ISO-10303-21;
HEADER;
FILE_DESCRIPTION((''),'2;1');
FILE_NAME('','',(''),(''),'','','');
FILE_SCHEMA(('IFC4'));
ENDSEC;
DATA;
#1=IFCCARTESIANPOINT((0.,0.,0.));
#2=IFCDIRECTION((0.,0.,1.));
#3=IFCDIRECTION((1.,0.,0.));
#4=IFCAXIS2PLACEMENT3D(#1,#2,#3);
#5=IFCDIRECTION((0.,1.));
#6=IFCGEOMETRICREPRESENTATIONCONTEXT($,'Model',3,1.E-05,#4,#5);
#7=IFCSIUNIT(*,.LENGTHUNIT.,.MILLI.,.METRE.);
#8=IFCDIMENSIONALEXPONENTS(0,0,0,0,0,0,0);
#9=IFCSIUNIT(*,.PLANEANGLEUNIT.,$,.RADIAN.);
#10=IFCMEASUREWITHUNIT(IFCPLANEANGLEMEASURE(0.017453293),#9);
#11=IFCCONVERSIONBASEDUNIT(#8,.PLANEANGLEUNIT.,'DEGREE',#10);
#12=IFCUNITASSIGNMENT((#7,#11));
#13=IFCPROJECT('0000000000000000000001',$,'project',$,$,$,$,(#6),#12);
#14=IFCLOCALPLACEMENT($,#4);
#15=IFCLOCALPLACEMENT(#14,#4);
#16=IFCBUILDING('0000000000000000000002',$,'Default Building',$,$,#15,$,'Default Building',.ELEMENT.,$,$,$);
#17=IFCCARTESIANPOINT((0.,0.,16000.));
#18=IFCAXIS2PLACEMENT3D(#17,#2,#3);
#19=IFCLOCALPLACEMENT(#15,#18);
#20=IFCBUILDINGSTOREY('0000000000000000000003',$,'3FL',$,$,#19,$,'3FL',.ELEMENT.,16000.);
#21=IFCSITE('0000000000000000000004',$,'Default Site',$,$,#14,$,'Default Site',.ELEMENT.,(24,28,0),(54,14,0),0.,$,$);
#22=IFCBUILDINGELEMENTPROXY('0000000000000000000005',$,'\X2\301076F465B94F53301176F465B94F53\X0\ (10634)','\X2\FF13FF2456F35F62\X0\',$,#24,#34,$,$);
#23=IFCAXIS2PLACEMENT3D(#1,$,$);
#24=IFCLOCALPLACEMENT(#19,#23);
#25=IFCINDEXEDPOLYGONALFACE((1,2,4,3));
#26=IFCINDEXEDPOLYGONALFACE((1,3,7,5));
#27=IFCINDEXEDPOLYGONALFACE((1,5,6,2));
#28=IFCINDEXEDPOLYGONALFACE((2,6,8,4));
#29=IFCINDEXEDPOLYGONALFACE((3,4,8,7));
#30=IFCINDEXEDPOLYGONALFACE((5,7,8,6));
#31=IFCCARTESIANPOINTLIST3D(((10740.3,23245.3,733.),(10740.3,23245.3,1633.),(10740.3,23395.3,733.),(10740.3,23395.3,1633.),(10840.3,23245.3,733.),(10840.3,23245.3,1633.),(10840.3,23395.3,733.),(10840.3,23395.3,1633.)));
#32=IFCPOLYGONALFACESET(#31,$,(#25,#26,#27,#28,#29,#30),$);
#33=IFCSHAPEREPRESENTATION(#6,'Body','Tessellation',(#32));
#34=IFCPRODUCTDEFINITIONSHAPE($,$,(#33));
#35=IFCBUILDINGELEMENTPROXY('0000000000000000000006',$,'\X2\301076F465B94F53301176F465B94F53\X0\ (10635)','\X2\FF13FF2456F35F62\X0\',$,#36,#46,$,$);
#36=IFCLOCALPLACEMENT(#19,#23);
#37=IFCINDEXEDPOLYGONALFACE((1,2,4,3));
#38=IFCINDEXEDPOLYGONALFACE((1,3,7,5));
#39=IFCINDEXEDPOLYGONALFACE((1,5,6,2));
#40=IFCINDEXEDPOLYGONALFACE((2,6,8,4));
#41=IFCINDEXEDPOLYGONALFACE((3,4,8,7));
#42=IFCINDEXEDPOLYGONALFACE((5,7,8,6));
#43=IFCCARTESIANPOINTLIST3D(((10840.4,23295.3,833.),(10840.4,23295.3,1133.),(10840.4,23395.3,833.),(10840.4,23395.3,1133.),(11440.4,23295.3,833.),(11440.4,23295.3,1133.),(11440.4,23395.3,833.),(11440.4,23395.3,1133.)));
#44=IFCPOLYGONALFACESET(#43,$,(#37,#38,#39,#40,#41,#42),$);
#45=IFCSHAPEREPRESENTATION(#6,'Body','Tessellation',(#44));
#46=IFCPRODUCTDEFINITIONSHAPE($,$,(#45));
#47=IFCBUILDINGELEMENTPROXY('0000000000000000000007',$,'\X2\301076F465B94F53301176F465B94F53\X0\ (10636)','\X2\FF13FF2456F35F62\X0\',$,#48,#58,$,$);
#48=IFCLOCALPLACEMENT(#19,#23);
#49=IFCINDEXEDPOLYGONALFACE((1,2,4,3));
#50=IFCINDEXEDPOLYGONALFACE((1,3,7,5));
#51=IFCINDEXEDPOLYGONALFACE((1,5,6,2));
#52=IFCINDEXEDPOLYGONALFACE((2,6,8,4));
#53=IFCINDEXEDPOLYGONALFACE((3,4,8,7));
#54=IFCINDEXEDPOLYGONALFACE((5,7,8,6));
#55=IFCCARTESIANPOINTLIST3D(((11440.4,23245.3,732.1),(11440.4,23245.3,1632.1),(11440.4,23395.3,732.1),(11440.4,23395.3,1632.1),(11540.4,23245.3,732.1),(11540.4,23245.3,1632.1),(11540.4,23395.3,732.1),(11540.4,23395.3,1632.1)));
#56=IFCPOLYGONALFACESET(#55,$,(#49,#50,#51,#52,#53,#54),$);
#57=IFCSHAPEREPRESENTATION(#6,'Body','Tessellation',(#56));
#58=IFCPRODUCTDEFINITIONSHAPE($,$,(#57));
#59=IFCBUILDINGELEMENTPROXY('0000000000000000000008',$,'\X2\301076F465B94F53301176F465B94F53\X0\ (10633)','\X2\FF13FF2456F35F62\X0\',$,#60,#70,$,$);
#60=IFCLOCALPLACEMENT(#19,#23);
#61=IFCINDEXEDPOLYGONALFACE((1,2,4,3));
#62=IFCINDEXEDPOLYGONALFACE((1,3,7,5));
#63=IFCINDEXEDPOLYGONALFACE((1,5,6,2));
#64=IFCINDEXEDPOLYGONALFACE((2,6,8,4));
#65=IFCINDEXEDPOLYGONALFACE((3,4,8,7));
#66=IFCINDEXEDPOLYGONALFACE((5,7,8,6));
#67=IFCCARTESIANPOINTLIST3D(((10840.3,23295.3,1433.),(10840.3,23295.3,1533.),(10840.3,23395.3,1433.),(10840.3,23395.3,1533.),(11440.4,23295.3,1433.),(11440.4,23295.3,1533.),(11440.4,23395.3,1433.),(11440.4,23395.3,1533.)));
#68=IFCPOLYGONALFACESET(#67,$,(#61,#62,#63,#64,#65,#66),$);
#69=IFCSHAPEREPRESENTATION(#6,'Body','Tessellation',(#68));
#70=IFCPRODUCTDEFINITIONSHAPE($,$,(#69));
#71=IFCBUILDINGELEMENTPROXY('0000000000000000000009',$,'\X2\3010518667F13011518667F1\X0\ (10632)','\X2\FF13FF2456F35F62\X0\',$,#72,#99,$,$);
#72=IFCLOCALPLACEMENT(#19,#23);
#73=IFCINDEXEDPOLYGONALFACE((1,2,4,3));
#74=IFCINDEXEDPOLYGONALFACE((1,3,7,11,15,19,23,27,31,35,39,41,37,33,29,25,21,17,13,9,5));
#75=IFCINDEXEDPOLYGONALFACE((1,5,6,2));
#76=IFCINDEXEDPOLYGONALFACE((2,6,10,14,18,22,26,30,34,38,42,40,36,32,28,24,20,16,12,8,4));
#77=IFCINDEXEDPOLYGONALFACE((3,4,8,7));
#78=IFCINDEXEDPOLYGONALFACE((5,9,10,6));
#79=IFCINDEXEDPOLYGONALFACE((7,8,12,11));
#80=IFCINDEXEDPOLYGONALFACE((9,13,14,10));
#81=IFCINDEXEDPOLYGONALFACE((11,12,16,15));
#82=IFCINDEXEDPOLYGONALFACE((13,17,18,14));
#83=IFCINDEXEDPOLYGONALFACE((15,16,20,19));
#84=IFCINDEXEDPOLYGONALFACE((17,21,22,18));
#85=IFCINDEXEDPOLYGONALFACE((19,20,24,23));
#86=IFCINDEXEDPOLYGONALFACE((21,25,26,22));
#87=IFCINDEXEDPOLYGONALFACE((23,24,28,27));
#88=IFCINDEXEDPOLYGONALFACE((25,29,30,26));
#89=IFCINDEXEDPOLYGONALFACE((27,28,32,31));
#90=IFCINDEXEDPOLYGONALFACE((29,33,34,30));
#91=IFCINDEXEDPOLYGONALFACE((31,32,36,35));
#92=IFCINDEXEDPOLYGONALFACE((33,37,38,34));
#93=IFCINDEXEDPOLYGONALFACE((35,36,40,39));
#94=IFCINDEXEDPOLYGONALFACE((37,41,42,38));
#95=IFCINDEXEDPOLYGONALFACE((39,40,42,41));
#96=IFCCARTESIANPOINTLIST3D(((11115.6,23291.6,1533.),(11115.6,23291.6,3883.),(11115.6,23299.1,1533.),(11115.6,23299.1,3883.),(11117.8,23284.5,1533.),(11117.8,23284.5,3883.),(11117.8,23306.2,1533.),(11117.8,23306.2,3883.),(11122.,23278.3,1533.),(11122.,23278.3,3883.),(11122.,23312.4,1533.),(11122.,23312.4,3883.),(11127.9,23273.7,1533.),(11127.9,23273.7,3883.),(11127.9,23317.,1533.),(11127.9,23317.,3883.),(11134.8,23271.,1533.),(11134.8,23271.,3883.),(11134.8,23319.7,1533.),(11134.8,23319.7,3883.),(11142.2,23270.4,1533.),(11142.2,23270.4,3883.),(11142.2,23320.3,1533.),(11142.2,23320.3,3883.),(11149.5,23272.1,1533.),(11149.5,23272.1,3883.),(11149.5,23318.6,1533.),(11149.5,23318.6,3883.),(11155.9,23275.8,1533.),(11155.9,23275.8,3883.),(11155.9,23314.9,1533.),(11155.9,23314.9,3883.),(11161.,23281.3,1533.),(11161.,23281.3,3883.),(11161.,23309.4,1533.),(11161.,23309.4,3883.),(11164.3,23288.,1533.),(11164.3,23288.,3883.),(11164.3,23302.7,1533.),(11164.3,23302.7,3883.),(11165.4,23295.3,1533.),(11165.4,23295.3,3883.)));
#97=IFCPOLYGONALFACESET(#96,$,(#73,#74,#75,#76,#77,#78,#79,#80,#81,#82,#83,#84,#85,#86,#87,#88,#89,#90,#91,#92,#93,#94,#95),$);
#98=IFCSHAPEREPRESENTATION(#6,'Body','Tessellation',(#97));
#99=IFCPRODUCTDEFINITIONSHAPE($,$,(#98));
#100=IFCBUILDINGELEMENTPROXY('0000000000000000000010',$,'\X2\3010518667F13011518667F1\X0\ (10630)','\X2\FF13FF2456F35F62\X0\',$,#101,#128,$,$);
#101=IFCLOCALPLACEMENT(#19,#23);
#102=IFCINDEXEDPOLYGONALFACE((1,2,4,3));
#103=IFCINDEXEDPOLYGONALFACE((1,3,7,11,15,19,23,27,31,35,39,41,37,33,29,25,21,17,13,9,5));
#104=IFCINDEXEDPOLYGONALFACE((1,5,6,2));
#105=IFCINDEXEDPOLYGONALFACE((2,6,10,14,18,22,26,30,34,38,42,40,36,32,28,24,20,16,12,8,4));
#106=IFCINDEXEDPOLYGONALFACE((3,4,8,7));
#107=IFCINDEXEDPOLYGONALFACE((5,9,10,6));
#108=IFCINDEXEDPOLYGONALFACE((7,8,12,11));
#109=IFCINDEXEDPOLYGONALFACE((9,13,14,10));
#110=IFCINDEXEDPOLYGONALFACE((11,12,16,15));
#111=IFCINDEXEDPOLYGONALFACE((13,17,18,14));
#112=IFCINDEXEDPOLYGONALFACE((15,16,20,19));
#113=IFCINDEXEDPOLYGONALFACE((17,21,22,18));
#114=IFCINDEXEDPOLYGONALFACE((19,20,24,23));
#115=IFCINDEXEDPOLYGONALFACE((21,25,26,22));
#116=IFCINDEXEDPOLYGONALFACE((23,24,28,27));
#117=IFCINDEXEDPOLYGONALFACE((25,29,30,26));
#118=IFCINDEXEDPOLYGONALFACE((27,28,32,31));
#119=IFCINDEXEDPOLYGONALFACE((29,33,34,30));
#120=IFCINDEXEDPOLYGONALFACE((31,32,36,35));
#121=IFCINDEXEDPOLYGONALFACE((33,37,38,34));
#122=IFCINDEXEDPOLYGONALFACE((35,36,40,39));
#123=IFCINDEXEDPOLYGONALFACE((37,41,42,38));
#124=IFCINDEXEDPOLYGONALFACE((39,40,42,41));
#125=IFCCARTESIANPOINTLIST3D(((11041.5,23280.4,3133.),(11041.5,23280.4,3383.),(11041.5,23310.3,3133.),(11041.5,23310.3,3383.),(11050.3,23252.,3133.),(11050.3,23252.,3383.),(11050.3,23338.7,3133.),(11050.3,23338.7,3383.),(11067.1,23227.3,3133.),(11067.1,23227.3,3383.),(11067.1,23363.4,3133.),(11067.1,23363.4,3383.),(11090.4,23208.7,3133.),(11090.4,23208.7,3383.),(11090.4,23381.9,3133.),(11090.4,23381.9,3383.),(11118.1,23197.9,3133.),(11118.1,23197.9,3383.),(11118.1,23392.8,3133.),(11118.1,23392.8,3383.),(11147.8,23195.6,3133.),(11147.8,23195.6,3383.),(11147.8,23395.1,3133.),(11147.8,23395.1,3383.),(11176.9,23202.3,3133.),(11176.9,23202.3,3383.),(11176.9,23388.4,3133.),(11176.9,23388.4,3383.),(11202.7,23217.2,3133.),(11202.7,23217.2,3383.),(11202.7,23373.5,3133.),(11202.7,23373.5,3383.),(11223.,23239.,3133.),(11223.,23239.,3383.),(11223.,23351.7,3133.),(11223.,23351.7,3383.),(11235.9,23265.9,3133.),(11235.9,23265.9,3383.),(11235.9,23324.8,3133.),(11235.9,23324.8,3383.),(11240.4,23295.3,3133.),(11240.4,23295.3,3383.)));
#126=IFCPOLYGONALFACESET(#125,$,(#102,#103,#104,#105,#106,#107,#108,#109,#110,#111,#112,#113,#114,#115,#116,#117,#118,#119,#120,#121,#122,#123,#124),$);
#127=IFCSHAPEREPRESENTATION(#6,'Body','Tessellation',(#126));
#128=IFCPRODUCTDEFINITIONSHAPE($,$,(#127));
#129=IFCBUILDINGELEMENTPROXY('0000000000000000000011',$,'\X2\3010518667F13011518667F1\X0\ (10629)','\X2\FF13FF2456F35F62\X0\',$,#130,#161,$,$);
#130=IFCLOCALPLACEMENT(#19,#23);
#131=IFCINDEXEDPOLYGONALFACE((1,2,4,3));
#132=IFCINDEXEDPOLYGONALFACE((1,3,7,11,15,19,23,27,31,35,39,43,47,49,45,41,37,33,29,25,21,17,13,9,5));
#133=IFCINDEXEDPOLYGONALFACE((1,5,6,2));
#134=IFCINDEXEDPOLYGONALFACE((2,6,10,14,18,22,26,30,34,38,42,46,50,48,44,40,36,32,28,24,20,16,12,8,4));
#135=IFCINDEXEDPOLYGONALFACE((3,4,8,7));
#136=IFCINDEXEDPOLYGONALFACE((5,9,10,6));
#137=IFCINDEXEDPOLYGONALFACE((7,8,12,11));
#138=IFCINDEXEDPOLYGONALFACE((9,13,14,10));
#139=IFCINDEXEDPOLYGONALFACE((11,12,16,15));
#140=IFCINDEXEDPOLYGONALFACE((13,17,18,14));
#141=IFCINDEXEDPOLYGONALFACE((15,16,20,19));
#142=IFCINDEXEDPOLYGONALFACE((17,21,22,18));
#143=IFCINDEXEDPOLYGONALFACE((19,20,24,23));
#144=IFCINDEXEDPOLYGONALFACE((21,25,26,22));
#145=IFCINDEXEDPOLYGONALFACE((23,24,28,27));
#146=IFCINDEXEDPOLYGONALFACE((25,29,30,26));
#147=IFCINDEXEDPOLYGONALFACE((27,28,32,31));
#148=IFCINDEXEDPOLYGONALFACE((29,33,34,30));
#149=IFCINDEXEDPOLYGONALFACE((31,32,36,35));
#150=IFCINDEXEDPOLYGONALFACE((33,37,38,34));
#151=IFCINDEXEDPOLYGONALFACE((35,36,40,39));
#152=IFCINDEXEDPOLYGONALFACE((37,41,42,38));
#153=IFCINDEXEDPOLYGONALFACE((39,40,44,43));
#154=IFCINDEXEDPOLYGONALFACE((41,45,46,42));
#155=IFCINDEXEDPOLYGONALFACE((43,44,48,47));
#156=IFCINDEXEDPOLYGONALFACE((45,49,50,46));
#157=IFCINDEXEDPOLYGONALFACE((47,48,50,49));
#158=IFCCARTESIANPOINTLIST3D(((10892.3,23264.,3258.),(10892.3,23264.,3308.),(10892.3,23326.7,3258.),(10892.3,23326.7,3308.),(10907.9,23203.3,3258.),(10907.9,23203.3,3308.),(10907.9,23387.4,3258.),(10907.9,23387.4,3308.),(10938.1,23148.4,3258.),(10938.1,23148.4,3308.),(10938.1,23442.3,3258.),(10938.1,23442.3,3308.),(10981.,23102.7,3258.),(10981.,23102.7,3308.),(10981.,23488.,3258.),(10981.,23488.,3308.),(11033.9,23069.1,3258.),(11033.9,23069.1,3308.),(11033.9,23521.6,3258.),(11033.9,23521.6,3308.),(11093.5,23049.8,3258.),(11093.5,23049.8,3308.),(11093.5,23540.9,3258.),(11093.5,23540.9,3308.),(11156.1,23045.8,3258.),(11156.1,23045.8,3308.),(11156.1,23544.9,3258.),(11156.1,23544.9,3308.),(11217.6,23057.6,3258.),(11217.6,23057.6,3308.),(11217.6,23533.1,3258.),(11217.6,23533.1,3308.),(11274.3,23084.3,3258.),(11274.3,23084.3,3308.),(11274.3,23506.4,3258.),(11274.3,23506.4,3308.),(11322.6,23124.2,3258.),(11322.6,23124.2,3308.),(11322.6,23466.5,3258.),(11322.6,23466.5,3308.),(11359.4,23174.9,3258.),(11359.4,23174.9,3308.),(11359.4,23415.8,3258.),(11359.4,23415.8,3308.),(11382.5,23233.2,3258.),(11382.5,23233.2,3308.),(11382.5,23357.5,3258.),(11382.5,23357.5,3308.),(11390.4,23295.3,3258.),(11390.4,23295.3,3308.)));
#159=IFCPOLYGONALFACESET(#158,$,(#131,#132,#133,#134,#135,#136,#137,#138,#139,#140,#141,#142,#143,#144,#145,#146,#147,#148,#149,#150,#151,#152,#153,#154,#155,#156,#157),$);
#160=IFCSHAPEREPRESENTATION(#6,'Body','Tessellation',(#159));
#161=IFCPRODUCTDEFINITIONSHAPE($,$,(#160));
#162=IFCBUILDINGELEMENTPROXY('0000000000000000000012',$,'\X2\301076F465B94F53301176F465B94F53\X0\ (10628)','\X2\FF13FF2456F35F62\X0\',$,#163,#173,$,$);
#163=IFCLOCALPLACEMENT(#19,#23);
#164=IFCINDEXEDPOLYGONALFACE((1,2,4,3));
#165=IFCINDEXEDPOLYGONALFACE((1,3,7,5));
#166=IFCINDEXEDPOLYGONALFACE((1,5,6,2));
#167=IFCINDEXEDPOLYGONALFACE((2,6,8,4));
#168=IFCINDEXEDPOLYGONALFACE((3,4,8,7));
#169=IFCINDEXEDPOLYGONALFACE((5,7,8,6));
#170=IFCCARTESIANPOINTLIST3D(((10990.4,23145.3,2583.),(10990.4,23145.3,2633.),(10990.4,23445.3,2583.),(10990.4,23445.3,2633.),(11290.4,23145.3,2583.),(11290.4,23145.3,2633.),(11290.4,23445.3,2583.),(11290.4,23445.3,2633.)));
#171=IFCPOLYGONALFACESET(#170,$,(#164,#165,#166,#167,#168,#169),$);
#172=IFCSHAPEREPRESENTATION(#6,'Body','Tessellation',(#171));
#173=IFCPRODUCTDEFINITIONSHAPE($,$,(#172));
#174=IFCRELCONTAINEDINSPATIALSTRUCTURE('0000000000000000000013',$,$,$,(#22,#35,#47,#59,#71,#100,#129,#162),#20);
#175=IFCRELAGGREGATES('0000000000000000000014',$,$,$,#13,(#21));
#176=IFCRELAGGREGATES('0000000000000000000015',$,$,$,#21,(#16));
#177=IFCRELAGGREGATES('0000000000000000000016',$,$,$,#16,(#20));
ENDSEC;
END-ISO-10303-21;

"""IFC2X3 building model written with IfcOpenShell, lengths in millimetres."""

from ifc_helpers import new_model, entity, si_unit, converted_unit, direction, frame, origin_with_axes, origin_2d_with_axis, place, context, project, spatial, rectangle, circle, extrude, source, transform, mapped, element, save


model = new_model("IFC2X3")

# Units and contexts
model_context = context("Model", 3, precision=1e-05, world=origin_with_axes(), true_north=direction((0.0, 1.0)))
ifc_project = project(units=[si_unit("LENGTHUNIT", "METRE", prefix="MILLI"), converted_unit("PLANEANGLEUNIT", "DEGREE", entity("IfcPlaneAngleMeasure", 0.017453293), si_unit("PLANEANGLEUNIT", "RADIAN"), dimensions=[0, 0, 0, 0, 0, 0, 0])], contexts=[model_context])

# Site, building, storey
site_placement = place(None, origin_with_axes())
site = spatial("IfcSite", under=ifc_project, at=site_placement, Name="Default Site", LongName="Default Site", CompositionType="ELEMENT", RefLatitude=(24, 28, 0), RefLongitude=(54, 14, 0), RefElevation=0.0)
building_placement = place(site_placement, origin_with_axes())
building = spatial("IfcBuilding", under=site, at=building_placement, Name="Default Building", LongName="Default Building", CompositionType="ELEMENT")
storey_placement = place(building_placement, frame((0.0, 0.0, 16000.0), z_axis=(0.0, 0.0, 1.0), x_axis=(1.0, 0.0, 0.0)))
storey = spatial("IfcBuildingStorey", under=building, at=storey_placement, Name="3FL", LongName="3FL", CompositionType="ELEMENT", Elevation=16000.0)

# Building element proxies
shared_shape_1 = source(origin_with_axes(), model_context, "Body", "SweptSolid", [
    extrude(rectangle(XDim=100.0, YDim=150.0, at=origin_2d_with_axis()), origin_with_axes(), (0.0, 0.0, 1.0), 900.0),
])
proxy_1_placement = place(storey_placement, frame((10790.3, 23320.3, 733.0), z_axis=(0.0, 0.0, 1.0), x_axis=(1.0, 0.0, 0.0)))
element("IfcBuildingElementProxy", 1, at=proxy_1_placement, inside=storey, Name="【直方体】直方体 (10634)", Description="３Ｄ図形", context=model_context, shape_type="MappedRepresentation", body=[
    mapped(shared_shape_1, transform((0.0, 0.0, 0.0))),
])
shared_shape_2 = source(origin_with_axes(), model_context, "Body", "SweptSolid", [
    extrude(rectangle(XDim=600.0, YDim=100.0, at=origin_2d_with_axis()), origin_with_axes(), (0.0, 0.0, 1.0), 300.0),
])
proxy_2_placement = place(storey_placement, frame((11140.4, 23345.3, 833.0), z_axis=(0.0, 0.0, 1.0), x_axis=(1.0, 0.0, 0.0)))
element("IfcBuildingElementProxy", 2, at=proxy_2_placement, inside=storey, Name="【直方体】直方体 (10635)", Description="３Ｄ図形", context=model_context, shape_type="MappedRepresentation", body=[
    mapped(shared_shape_2, transform((0.0, 0.0, 0.0))),
])
shared_shape_3 = source(origin_with_axes(), model_context, "Body", "SweptSolid", [
    extrude(rectangle(XDim=100.0, YDim=150.0, at=origin_2d_with_axis()), origin_with_axes(), (0.0, 0.0, 1.0), 900.0),
])
proxy_3_placement = place(storey_placement, frame((11490.4, 23320.3, 732.1), z_axis=(0.0, 0.0, 1.0), x_axis=(1.0, 0.0, 0.0)))
element("IfcBuildingElementProxy", 3, at=proxy_3_placement, inside=storey, Name="【直方体】直方体 (10636)", Description="３Ｄ図形", context=model_context, shape_type="MappedRepresentation", body=[
    mapped(shared_shape_3, transform((0.0, 0.0, 0.0))),
])
shared_shape_4 = source(origin_with_axes(), model_context, "Body", "SweptSolid", [
    extrude(rectangle(XDim=600.2, YDim=100.0, at=origin_2d_with_axis()), origin_with_axes(), (0.0, 0.0, 1.0), 100.0),
])
proxy_4_placement = place(storey_placement, frame((11140.4, 23345.3, 1433.0), z_axis=(0.0, 0.0, 1.0), x_axis=(1.0, 0.0, 0.0)))
element("IfcBuildingElementProxy", 4, at=proxy_4_placement, inside=storey, Name="【直方体】直方体 (10633)", Description="３Ｄ図形", context=model_context, shape_type="MappedRepresentation", body=[
    mapped(shared_shape_4, transform((0.0, 0.0, 0.0))),
])
shared_shape_5 = source(origin_with_axes(), model_context, "Body", "SweptSolid", [
    extrude(circle(Radius=25.0, at=origin_2d_with_axis()), origin_with_axes(), (0.0, 0.0, 1.0), 2350.0),
])
proxy_5_placement = place(storey_placement, frame((11140.4, 23295.3, 1533.0), z_axis=(0.0, 0.0, 1.0), x_axis=(1.0, 0.0, 0.0)))
element("IfcBuildingElementProxy", 5, at=proxy_5_placement, inside=storey, Name="【円柱】円柱 (10632)", Description="３Ｄ図形", context=model_context, shape_type="MappedRepresentation", body=[
    mapped(shared_shape_5, transform((0.0, 0.0, 0.0))),
])
shared_shape_6 = source(origin_with_axes(), model_context, "Body", "SweptSolid", [
    extrude(circle(Radius=100.0, at=origin_2d_with_axis()), origin_with_axes(), (0.0, 0.0, 1.0), 250.0),
])
proxy_6_placement = place(storey_placement, frame((11140.4, 23295.3, 3133.0), z_axis=(0.0, 0.0, 1.0), x_axis=(1.0, 0.0, 0.0)))
element("IfcBuildingElementProxy", 6, at=proxy_6_placement, inside=storey, Name="【円柱】円柱 (10630)", Description="３Ｄ図形", context=model_context, shape_type="MappedRepresentation", body=[
    mapped(shared_shape_6, transform((0.0, 0.0, 0.0))),
])
shared_shape_7 = source(origin_with_axes(), model_context, "Body", "SweptSolid", [
    extrude(circle(Radius=250.0, at=origin_2d_with_axis()), origin_with_axes(), (0.0, 0.0, 1.0), 50.0),
])
proxy_7_placement = place(storey_placement, frame((11140.4, 23295.3, 3258.0), z_axis=(0.0, 0.0, 1.0), x_axis=(1.0, 0.0, 0.0)))
element("IfcBuildingElementProxy", 7, at=proxy_7_placement, inside=storey, Name="【円柱】円柱 (10629)", Description="３Ｄ図形", context=model_context, shape_type="MappedRepresentation", body=[
    mapped(shared_shape_7, transform((0.0, 0.0, 0.0))),
])
shared_shape_8 = source(origin_with_axes(), model_context, "Body", "SweptSolid", [
    extrude(rectangle(XDim=300.0, YDim=300.0, at=origin_2d_with_axis()), origin_with_axes(), (0.0, 0.0, 1.0), 50.0),
])
proxy_8_placement = place(storey_placement, frame((11140.4, 23295.3, 2583.0), z_axis=(0.0, 0.0, 1.0), x_axis=(1.0, 0.0, 0.0)))
element("IfcBuildingElementProxy", 8, at=proxy_8_placement, inside=storey, Name="【直方体】直方体 (10628)", Description="３Ｄ図形", context=model_context, shape_type="MappedRepresentation", body=[
    mapped(shared_shape_8, transform((0.0, 0.0, 0.0))),
])

save(model, "model.ifc")
